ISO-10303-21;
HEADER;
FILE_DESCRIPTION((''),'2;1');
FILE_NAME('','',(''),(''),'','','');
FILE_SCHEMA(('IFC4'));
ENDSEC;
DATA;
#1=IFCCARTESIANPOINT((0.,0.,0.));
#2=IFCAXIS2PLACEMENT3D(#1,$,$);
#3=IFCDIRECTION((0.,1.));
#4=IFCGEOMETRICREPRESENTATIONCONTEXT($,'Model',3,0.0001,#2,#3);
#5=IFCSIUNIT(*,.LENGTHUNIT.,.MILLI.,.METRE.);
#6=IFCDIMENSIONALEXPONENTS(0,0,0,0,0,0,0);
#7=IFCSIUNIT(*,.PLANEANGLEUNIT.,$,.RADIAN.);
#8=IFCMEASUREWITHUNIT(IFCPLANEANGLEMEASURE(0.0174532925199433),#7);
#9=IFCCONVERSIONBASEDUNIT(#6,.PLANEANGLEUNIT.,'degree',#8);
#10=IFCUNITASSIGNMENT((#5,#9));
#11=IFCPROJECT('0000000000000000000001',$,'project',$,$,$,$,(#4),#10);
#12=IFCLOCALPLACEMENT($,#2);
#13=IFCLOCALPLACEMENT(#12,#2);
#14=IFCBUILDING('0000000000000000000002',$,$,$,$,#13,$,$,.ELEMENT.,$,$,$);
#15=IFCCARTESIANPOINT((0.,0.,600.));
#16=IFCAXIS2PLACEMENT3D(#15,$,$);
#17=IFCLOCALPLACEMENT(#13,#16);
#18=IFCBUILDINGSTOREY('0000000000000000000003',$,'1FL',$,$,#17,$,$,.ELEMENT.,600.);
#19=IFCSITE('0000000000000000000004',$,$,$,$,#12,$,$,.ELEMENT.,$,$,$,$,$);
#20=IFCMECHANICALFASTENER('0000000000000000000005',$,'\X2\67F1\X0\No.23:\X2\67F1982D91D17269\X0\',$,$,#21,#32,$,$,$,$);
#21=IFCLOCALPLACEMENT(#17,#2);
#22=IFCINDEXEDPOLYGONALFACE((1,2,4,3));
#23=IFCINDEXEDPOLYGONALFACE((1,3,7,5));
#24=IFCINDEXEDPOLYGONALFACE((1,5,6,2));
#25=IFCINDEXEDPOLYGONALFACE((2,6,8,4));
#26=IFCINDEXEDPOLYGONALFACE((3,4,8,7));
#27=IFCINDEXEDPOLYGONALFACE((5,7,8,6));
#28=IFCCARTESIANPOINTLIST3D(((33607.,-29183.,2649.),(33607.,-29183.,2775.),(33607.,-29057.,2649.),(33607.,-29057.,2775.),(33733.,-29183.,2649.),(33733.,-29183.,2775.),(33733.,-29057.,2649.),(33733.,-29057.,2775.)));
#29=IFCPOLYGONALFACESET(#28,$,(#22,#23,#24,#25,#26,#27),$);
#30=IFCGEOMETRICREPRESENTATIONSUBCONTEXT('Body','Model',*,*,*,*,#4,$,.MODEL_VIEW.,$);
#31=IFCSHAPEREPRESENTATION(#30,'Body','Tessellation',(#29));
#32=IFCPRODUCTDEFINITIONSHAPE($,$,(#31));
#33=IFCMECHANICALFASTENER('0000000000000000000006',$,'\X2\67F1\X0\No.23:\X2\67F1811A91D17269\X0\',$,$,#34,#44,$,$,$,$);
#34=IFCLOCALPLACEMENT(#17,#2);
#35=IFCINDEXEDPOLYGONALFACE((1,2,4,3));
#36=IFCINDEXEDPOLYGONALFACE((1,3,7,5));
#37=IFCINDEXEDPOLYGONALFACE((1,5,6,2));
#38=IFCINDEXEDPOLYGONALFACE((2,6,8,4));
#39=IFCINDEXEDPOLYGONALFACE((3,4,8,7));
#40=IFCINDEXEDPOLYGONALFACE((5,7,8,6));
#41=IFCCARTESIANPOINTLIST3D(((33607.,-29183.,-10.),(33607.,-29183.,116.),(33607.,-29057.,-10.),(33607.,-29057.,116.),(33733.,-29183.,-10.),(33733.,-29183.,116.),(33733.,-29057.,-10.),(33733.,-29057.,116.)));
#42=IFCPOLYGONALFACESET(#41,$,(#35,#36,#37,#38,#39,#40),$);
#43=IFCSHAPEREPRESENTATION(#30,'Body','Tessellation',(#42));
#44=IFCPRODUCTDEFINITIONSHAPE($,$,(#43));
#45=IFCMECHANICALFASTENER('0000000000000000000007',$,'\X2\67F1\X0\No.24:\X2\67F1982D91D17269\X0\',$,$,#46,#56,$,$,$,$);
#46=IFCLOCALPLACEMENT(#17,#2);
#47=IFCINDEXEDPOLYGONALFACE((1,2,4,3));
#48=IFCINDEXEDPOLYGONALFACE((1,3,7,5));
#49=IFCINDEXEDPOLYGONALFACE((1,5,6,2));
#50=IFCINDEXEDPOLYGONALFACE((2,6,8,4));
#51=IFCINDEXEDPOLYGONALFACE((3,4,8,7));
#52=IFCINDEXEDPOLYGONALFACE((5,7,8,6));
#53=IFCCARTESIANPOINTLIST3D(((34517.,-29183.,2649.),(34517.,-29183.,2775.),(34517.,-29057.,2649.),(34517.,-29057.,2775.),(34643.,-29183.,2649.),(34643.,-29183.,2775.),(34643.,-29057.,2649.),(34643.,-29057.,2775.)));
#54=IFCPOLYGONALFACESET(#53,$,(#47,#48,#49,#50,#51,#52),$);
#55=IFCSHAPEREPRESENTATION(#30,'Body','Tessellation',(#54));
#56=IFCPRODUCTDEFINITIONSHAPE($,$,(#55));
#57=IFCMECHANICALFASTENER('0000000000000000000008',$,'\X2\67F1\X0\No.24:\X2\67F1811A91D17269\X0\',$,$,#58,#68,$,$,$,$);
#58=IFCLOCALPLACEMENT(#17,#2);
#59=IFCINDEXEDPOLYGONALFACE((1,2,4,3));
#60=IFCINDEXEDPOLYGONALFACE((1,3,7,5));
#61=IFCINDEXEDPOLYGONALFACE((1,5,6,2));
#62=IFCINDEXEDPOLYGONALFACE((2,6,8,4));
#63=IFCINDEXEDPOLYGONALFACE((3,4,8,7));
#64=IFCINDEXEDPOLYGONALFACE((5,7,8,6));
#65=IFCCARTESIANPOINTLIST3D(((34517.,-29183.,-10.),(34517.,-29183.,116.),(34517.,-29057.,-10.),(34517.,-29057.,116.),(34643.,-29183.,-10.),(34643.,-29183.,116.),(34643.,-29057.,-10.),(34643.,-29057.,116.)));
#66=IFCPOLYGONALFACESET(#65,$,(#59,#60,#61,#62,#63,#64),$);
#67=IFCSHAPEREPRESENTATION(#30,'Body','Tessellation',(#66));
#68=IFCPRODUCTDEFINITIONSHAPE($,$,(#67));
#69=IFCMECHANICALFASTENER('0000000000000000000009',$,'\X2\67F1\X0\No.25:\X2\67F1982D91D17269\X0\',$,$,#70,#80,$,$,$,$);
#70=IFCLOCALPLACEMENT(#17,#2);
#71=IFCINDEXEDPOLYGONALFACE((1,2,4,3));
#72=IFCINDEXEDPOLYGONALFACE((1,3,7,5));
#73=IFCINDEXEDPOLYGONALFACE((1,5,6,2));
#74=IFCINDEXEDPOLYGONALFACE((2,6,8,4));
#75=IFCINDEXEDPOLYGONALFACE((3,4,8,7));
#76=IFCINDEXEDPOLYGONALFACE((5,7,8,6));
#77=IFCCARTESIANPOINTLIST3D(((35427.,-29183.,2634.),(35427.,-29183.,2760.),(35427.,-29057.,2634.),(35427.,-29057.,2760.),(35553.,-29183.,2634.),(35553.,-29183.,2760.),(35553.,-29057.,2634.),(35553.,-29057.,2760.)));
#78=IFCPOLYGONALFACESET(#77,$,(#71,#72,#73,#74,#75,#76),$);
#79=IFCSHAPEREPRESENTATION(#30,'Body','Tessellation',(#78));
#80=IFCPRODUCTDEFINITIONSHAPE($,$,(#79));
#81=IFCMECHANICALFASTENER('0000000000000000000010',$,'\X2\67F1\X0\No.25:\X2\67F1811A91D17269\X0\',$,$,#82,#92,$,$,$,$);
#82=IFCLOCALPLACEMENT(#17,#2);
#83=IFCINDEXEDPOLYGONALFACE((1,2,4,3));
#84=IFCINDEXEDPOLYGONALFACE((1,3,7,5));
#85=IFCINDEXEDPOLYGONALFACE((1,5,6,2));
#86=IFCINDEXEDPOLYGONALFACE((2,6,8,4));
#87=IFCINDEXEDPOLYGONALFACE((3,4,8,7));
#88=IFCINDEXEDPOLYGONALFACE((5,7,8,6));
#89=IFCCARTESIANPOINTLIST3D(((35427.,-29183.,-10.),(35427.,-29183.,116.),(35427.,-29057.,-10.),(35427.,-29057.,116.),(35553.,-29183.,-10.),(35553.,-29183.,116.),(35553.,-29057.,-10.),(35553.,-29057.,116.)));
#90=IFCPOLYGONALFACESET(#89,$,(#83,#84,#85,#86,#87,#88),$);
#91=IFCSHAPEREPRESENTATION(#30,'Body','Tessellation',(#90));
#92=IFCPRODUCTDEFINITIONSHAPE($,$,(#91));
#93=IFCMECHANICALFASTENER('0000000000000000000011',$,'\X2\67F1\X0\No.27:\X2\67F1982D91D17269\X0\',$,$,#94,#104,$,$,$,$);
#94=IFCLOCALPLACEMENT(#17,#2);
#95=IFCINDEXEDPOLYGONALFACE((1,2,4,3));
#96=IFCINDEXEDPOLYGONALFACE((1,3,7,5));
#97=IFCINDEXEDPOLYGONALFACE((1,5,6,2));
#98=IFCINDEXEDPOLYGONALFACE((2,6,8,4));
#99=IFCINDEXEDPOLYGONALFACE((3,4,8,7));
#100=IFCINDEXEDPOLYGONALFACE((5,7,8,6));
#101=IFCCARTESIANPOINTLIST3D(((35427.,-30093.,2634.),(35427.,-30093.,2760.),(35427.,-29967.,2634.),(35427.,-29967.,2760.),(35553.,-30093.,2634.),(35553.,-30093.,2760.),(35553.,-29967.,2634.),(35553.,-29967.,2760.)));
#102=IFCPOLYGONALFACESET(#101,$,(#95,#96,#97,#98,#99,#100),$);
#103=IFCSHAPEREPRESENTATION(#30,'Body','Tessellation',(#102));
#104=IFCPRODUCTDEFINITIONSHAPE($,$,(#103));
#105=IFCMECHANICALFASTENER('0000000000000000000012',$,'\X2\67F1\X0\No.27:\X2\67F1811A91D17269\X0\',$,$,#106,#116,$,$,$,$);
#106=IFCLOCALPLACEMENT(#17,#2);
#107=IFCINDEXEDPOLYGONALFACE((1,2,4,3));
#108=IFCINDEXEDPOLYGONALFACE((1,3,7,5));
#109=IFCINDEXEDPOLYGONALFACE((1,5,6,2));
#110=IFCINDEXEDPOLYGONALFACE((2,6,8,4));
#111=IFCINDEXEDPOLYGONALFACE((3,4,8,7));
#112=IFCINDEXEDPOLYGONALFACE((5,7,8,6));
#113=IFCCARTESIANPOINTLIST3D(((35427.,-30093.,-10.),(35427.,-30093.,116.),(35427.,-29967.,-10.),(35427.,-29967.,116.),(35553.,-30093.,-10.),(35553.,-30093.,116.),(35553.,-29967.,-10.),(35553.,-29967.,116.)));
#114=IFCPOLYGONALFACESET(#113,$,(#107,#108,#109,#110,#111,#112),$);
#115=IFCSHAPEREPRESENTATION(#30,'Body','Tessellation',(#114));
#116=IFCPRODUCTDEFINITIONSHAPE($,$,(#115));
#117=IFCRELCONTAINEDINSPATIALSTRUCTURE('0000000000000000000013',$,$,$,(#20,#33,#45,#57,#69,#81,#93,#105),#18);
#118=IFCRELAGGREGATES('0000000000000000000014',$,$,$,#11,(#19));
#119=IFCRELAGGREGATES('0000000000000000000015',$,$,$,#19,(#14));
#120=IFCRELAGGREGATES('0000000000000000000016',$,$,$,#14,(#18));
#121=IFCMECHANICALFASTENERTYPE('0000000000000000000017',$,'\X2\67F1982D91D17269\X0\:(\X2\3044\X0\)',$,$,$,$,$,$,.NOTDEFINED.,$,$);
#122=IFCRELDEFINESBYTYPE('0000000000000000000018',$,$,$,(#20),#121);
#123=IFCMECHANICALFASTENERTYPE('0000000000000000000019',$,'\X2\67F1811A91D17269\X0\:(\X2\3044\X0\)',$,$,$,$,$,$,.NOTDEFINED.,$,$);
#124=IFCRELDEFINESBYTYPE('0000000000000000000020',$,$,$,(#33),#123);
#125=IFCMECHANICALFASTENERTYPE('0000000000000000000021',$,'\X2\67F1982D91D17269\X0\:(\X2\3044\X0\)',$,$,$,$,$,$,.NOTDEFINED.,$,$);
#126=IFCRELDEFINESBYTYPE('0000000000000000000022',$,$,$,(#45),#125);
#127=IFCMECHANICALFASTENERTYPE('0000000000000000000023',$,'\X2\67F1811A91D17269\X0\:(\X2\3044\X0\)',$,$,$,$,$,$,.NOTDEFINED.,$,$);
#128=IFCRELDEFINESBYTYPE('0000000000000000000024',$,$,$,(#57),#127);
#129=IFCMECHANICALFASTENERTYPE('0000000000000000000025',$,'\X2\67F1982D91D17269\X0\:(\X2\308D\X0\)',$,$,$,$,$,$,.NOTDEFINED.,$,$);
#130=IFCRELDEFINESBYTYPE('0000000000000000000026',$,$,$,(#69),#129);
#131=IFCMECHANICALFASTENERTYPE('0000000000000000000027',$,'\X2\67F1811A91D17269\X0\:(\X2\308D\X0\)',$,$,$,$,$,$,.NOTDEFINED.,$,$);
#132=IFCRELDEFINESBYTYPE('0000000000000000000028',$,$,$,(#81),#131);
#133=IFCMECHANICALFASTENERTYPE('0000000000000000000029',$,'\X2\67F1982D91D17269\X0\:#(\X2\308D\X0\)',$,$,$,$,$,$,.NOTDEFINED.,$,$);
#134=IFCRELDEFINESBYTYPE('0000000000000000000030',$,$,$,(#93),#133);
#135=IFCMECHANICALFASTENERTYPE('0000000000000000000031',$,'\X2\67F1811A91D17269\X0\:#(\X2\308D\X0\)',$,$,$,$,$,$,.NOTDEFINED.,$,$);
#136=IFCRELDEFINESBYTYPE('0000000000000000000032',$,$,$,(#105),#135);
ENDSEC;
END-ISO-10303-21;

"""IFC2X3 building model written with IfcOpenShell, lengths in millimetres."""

from ifc_helpers import new_model, entity, si_unit, converted_unit, direction, frame, origin, origin_with_axes, origin_2d, place, context, subcontext, project, spatial, rectangle, extrude, type_object, element, save


model = new_model("IFC2X3")

# Units and contexts
model_context = context("Model", 3, precision=0.0001, world=origin(), true_north=direction((0.0, 1.0)))
body_context = subcontext(model_context, "Body", "Model", "MODEL_VIEW")
ifc_project = project(units=[si_unit("LENGTHUNIT", "METRE", prefix="MILLI"), converted_unit("PLANEANGLEUNIT", "degree", entity("IfcPlaneAngleMeasure", 0.0174532925199433), si_unit("PLANEANGLEUNIT", "RADIAN"), dimensions=[0, 0, 0, 0, 0, 0, 0])], contexts=[model_context])

# Site, building, storey
site_placement = place(None, origin())
site = spatial("IfcSite", under=ifc_project, at=site_placement, CompositionType="ELEMENT")
building_placement = place(site_placement, origin())
building = spatial("IfcBuilding", under=site, at=building_placement, CompositionType="ELEMENT")
storey_placement = place(building_placement, frame((0.0, 0.0, 600.0)))
storey = spatial("IfcBuildingStorey", under=building, at=storey_placement, Name="1FL", CompositionType="ELEMENT", Elevation=600.0)

# Mechanical fasteners
mechanical_fastener_type_1 = type_object("IfcMechanicalFastenerType", Name="柱頭金物:(い)")
mechanical_fastener_1_placement = place(storey_placement, frame((33670.0, -29120.0, 2649.0)))
element("IfcMechanicalFastener", 1, at=mechanical_fastener_1_placement, inside=storey, type_object=mechanical_fastener_type_1, Name="柱No.23:柱頭金物", context=body_context, shape_type="SweptSolid", body=[
    extrude(rectangle(XDim=126.0, YDim=126.0, at=origin_2d()), origin_with_axes(), (0.0, 0.0, 1.0), 126.0),
])
mechanical_fastener_type_2 = type_object("IfcMechanicalFastenerType", Name="柱脚金物:(い)")
mechanical_fastener_2_placement = place(storey_placement, frame((33670.0, -29120.0, -10.0)))
element("IfcMechanicalFastener", 2, at=mechanical_fastener_2_placement, inside=storey, type_object=mechanical_fastener_type_2, Name="柱No.23:柱脚金物", context=body_context, shape_type="SweptSolid", body=[
    extrude(rectangle(XDim=126.0, YDim=126.0, at=origin_2d()), origin_with_axes(), (0.0, 0.0, 1.0), 126.0),
])
mechanical_fastener_type_3 = type_object("IfcMechanicalFastenerType", Name="柱頭金物:(い)")
mechanical_fastener_3_placement = place(storey_placement, frame((34580.0, -29120.0, 2649.0)))
element("IfcMechanicalFastener", 3, at=mechanical_fastener_3_placement, inside=storey, type_object=mechanical_fastener_type_3, Name="柱No.24:柱頭金物", context=body_context, shape_type="SweptSolid", body=[
    extrude(rectangle(XDim=126.0, YDim=126.0, at=origin_2d()), origin_with_axes(), (0.0, 0.0, 1.0), 126.0),
])
mechanical_fastener_type_4 = type_object("IfcMechanicalFastenerType", Name="柱脚金物:(い)")
mechanical_fastener_4_placement = place(storey_placement, frame((34580.0, -29120.0, -10.0)))
element("IfcMechanicalFastener", 4, at=mechanical_fastener_4_placement, inside=storey, type_object=mechanical_fastener_type_4, Name="柱No.24:柱脚金物", context=body_context, shape_type="SweptSolid", body=[
    extrude(rectangle(XDim=126.0, YDim=126.0, at=origin_2d()), origin_with_axes(), (0.0, 0.0, 1.0), 126.0),
])
mechanical_fastener_type_5 = type_object("IfcMechanicalFastenerType", Name="柱頭金物:(ろ)")
mechanical_fastener_5_placement = place(storey_placement, frame((35490.0, -29120.0, 2634.0)))
element("IfcMechanicalFastener", 5, at=mechanical_fastener_5_placement, inside=storey, type_object=mechanical_fastener_type_5, Name="柱No.25:柱頭金物", context=body_context, shape_type="SweptSolid", body=[
    extrude(rectangle(XDim=126.0, YDim=126.0, at=origin_2d()), origin_with_axes(), (0.0, 0.0, 1.0), 126.0),
])
mechanical_fastener_type_6 = type_object("IfcMechanicalFastenerType", Name="柱脚金物:(ろ)")
mechanical_fastener_6_placement = place(storey_placement, frame((35490.0, -29120.0, -10.0)))
element("IfcMechanicalFastener", 6, at=mechanical_fastener_6_placement, inside=storey, type_object=mechanical_fastener_type_6, Name="柱No.25:柱脚金物", context=body_context, shape_type="SweptSolid", body=[
    extrude(rectangle(XDim=126.0, YDim=126.0, at=origin_2d()), origin_with_axes(), (0.0, 0.0, 1.0), 126.0),
])
mechanical_fastener_type_7 = type_object("IfcMechanicalFastenerType", Name="柱頭金物:#(ろ)")
mechanical_fastener_7_placement = place(storey_placement, frame((35490.0, -30030.0, 2634.0)))
element("IfcMechanicalFastener", 7, at=mechanical_fastener_7_placement, inside=storey, type_object=mechanical_fastener_type_7, Name="柱No.27:柱頭金物", context=body_context, shape_type="SweptSolid", body=[
    extrude(rectangle(XDim=126.0, YDim=126.0, at=origin_2d()), origin_with_axes(), (0.0, 0.0, 1.0), 126.0),
])
mechanical_fastener_type_8 = type_object("IfcMechanicalFastenerType", Name="柱脚金物:#(ろ)")
mechanical_fastener_8_placement = place(storey_placement, frame((35490.0, -30030.0, -10.0)))
element("IfcMechanicalFastener", 8, at=mechanical_fastener_8_placement, inside=storey, type_object=mechanical_fastener_type_8, Name="柱No.27:柱脚金物", context=body_context, shape_type="SweptSolid", body=[
    extrude(rectangle(XDim=126.0, YDim=126.0, at=origin_2d()), origin_with_axes(), (0.0, 0.0, 1.0), 126.0),
])

save(model, "model.ifc")
